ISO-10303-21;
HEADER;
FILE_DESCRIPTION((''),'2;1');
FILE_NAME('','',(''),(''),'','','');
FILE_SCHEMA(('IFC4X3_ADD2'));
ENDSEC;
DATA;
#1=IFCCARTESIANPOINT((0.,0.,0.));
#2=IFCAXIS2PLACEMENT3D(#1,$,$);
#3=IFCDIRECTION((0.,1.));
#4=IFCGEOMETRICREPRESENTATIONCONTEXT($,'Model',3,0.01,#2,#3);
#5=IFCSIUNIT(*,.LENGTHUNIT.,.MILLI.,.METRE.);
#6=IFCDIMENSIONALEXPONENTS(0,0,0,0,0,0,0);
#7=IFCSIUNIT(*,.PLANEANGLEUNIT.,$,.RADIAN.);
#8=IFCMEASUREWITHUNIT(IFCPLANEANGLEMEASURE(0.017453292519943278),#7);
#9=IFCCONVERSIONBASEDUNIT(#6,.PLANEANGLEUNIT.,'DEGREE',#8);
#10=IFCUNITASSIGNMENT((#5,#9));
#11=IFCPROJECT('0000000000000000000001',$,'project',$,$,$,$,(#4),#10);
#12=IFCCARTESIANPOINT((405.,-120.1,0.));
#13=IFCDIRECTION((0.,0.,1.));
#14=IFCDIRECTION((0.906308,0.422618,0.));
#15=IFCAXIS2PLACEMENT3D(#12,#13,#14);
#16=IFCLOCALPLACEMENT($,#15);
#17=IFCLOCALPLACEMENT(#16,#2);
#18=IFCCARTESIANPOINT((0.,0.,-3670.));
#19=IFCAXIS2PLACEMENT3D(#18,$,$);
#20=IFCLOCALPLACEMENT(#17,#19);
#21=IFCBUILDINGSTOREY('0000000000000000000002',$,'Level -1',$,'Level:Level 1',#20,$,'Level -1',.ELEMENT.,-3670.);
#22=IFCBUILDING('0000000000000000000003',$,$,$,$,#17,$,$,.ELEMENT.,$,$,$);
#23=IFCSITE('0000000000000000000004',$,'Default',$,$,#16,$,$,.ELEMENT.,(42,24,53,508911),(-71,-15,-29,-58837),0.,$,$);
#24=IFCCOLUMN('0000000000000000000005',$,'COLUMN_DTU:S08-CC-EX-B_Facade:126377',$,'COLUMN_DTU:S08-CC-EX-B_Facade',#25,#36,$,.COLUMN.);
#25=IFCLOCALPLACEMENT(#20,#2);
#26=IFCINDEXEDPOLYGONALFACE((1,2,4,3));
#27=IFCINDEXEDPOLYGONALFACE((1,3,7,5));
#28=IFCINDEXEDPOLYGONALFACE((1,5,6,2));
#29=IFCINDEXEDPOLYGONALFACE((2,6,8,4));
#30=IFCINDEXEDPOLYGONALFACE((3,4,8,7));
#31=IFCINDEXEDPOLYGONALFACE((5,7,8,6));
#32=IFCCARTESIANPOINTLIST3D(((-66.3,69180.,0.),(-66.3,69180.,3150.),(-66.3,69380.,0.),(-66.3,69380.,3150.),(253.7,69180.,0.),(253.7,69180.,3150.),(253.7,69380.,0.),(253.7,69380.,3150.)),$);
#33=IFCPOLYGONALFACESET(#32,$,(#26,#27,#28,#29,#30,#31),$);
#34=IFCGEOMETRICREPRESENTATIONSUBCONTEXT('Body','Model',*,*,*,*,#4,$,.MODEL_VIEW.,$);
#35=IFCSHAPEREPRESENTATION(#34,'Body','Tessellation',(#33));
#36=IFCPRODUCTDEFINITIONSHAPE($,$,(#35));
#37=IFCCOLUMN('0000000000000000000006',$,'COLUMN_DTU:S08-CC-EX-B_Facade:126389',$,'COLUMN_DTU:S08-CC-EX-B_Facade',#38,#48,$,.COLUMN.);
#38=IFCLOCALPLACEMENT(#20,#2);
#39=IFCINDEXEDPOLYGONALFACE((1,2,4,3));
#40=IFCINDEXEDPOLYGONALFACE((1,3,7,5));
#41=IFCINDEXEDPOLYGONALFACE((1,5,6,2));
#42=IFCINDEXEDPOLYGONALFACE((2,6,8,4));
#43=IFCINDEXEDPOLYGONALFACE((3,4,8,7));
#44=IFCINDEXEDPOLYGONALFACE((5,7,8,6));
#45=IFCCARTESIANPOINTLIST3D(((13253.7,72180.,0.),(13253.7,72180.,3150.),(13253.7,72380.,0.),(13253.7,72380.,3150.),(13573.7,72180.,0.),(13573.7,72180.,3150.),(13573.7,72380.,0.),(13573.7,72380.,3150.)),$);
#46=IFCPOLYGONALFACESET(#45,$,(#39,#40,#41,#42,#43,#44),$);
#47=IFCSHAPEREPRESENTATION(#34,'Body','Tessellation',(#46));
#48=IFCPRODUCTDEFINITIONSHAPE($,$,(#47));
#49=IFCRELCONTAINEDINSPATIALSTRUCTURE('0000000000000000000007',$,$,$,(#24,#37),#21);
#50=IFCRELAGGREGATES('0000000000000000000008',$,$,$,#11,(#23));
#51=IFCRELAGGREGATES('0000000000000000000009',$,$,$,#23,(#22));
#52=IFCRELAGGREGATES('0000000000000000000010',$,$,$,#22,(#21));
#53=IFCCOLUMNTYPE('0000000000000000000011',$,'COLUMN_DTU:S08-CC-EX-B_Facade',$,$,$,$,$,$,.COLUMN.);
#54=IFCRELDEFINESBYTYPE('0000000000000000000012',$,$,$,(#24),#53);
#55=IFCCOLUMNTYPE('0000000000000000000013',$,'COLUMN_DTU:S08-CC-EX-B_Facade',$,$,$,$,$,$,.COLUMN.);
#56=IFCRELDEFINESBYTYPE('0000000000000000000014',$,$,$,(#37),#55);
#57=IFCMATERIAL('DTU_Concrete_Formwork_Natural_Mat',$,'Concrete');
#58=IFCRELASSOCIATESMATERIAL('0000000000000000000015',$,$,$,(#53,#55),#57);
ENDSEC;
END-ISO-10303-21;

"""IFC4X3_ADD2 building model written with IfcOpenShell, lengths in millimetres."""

from ifc_helpers import new_model, entity, si_unit, converted_unit, direction, frame, frame_2d, origin, origin_2d_with_axis, place, context, subcontext, project, spatial, rectangle, extrude, source, transform, mapped, material, material_profile, profile_set, type_object, type_shapes, element, save


model = new_model("IFC4X3_ADD2")

# Units and contexts
model_context = context("Model", 3, precision=0.01, world=origin(), true_north=direction((0.0, 1.0)))
body_context = subcontext(model_context, "Body", "Model", "MODEL_VIEW")
ifc_project = project(units=[si_unit("LENGTHUNIT", "METRE", prefix="MILLI"), converted_unit("PLANEANGLEUNIT", "DEGREE", entity("IfcPlaneAngleMeasure", 0.017453292519943278), si_unit("PLANEANGLEUNIT", "RADIAN"), dimensions=[0, 0, 0, 0, 0, 0, 0])], contexts=[model_context])

# Site, building, storey
site_placement = place(None, frame((405.0, -120.1, 0.0), z_axis=(0.0, 0.0, 1.0), x_axis=(0.906308, 0.422618, 0.0)))
site = spatial("IfcSite", under=ifc_project, at=site_placement, Name="Default", CompositionType="ELEMENT", RefLatitude=(42, 24, 53, 508911), RefLongitude=(-71, -15, -29, -58837), RefElevation=0.0)
building_placement = place(site_placement, origin())
building = spatial("IfcBuilding", under=site, at=building_placement, CompositionType="ELEMENT")
storey_placement = place(building_placement, frame((0.0, 0.0, -3670.0)))
storey = spatial("IfcBuildingStorey", under=building, at=storey_placement, Name="Level -1", ObjectType="Level:Level 1", LongName="Level -1", CompositionType="ELEMENT", Elevation=-3670.0)

# Columns
ifc_material = material(Name="DTU_Concrete_Formwork_Natural_Mat", Category="Concrete")
ifc_material_profile_1 = material_profile(ifc_material, rectangle(XDim=200.0, YDim=320.0, at=origin_2d_with_axis()), Name="S08-CC-EX-B_Facade")
ifc_profile_set_1 = profile_set([ifc_material_profile_1], Name="S08-CC-EX-B_Facade")
column_type_1 = type_object("IfcColumnType", Name="COLUMN_DTU:S08-CC-EX-B_Facade", PredefinedType="COLUMN", material=ifc_profile_set_1)
shared_shape_1 = source(origin(), body_context, "Body", "SweptSolid", [
    extrude(rectangle(XDim=200.0, YDim=320.0, at=origin_2d_with_axis()), frame((93.7, 69280.0, -3670.0), z_axis=(0.0, 0.0, 1.0), x_axis=(0.0, -1.0, 0.0)), (0.0, 0.0, 1.0), 3150.0),
])
type_shapes(column_type_1, [shared_shape_1])
column_1_placement = place(storey_placement, frame((0.0, 0.0, 3670.0)))
element("IfcColumn", 1, at=column_1_placement, inside=storey, type_object=column_type_1, Name="COLUMN_DTU:S08-CC-EX-B_Facade:126377", ObjectType="COLUMN_DTU:S08-CC-EX-B_Facade", PredefinedType="COLUMN", context=body_context, shape_type="MappedRepresentation", body=[
    mapped(shared_shape_1, transform((0.0, 0.0, 0.0), scale=1.0)),
])
column_type_2 = type_object("IfcColumnType", Name="COLUMN_DTU:S08-CC-EX-B_Facade", PredefinedType="COLUMN", material=ifc_profile_set_1)
shared_shape_2 = source(origin(), body_context, "Body", "SweptSolid", [
    extrude(rectangle(XDim=200.0, YDim=320.0, at=frame_2d((0.0, 0.0), x_axis=(1.0, 0.0))), frame((13413.7, 72280.0, -3670.0), z_axis=(0.0, 0.0, 1.0), x_axis=(0.0, 1.0, 0.0)), (0.0, 0.0, 1.0), 3150.0),
])
type_shapes(column_type_2, [shared_shape_2])
column_2_placement = place(storey_placement, frame((0.0, 0.0, 3670.0)))
element("IfcColumn", 2, at=column_2_placement, inside=storey, type_object=column_type_2, Name="COLUMN_DTU:S08-CC-EX-B_Facade:126389", ObjectType="COLUMN_DTU:S08-CC-EX-B_Facade", PredefinedType="COLUMN", context=body_context, shape_type="MappedRepresentation", body=[
    mapped(shared_shape_2, transform((0.0, 0.0, 0.0), scale=1.0)),
])

save(model, "model.ifc")
